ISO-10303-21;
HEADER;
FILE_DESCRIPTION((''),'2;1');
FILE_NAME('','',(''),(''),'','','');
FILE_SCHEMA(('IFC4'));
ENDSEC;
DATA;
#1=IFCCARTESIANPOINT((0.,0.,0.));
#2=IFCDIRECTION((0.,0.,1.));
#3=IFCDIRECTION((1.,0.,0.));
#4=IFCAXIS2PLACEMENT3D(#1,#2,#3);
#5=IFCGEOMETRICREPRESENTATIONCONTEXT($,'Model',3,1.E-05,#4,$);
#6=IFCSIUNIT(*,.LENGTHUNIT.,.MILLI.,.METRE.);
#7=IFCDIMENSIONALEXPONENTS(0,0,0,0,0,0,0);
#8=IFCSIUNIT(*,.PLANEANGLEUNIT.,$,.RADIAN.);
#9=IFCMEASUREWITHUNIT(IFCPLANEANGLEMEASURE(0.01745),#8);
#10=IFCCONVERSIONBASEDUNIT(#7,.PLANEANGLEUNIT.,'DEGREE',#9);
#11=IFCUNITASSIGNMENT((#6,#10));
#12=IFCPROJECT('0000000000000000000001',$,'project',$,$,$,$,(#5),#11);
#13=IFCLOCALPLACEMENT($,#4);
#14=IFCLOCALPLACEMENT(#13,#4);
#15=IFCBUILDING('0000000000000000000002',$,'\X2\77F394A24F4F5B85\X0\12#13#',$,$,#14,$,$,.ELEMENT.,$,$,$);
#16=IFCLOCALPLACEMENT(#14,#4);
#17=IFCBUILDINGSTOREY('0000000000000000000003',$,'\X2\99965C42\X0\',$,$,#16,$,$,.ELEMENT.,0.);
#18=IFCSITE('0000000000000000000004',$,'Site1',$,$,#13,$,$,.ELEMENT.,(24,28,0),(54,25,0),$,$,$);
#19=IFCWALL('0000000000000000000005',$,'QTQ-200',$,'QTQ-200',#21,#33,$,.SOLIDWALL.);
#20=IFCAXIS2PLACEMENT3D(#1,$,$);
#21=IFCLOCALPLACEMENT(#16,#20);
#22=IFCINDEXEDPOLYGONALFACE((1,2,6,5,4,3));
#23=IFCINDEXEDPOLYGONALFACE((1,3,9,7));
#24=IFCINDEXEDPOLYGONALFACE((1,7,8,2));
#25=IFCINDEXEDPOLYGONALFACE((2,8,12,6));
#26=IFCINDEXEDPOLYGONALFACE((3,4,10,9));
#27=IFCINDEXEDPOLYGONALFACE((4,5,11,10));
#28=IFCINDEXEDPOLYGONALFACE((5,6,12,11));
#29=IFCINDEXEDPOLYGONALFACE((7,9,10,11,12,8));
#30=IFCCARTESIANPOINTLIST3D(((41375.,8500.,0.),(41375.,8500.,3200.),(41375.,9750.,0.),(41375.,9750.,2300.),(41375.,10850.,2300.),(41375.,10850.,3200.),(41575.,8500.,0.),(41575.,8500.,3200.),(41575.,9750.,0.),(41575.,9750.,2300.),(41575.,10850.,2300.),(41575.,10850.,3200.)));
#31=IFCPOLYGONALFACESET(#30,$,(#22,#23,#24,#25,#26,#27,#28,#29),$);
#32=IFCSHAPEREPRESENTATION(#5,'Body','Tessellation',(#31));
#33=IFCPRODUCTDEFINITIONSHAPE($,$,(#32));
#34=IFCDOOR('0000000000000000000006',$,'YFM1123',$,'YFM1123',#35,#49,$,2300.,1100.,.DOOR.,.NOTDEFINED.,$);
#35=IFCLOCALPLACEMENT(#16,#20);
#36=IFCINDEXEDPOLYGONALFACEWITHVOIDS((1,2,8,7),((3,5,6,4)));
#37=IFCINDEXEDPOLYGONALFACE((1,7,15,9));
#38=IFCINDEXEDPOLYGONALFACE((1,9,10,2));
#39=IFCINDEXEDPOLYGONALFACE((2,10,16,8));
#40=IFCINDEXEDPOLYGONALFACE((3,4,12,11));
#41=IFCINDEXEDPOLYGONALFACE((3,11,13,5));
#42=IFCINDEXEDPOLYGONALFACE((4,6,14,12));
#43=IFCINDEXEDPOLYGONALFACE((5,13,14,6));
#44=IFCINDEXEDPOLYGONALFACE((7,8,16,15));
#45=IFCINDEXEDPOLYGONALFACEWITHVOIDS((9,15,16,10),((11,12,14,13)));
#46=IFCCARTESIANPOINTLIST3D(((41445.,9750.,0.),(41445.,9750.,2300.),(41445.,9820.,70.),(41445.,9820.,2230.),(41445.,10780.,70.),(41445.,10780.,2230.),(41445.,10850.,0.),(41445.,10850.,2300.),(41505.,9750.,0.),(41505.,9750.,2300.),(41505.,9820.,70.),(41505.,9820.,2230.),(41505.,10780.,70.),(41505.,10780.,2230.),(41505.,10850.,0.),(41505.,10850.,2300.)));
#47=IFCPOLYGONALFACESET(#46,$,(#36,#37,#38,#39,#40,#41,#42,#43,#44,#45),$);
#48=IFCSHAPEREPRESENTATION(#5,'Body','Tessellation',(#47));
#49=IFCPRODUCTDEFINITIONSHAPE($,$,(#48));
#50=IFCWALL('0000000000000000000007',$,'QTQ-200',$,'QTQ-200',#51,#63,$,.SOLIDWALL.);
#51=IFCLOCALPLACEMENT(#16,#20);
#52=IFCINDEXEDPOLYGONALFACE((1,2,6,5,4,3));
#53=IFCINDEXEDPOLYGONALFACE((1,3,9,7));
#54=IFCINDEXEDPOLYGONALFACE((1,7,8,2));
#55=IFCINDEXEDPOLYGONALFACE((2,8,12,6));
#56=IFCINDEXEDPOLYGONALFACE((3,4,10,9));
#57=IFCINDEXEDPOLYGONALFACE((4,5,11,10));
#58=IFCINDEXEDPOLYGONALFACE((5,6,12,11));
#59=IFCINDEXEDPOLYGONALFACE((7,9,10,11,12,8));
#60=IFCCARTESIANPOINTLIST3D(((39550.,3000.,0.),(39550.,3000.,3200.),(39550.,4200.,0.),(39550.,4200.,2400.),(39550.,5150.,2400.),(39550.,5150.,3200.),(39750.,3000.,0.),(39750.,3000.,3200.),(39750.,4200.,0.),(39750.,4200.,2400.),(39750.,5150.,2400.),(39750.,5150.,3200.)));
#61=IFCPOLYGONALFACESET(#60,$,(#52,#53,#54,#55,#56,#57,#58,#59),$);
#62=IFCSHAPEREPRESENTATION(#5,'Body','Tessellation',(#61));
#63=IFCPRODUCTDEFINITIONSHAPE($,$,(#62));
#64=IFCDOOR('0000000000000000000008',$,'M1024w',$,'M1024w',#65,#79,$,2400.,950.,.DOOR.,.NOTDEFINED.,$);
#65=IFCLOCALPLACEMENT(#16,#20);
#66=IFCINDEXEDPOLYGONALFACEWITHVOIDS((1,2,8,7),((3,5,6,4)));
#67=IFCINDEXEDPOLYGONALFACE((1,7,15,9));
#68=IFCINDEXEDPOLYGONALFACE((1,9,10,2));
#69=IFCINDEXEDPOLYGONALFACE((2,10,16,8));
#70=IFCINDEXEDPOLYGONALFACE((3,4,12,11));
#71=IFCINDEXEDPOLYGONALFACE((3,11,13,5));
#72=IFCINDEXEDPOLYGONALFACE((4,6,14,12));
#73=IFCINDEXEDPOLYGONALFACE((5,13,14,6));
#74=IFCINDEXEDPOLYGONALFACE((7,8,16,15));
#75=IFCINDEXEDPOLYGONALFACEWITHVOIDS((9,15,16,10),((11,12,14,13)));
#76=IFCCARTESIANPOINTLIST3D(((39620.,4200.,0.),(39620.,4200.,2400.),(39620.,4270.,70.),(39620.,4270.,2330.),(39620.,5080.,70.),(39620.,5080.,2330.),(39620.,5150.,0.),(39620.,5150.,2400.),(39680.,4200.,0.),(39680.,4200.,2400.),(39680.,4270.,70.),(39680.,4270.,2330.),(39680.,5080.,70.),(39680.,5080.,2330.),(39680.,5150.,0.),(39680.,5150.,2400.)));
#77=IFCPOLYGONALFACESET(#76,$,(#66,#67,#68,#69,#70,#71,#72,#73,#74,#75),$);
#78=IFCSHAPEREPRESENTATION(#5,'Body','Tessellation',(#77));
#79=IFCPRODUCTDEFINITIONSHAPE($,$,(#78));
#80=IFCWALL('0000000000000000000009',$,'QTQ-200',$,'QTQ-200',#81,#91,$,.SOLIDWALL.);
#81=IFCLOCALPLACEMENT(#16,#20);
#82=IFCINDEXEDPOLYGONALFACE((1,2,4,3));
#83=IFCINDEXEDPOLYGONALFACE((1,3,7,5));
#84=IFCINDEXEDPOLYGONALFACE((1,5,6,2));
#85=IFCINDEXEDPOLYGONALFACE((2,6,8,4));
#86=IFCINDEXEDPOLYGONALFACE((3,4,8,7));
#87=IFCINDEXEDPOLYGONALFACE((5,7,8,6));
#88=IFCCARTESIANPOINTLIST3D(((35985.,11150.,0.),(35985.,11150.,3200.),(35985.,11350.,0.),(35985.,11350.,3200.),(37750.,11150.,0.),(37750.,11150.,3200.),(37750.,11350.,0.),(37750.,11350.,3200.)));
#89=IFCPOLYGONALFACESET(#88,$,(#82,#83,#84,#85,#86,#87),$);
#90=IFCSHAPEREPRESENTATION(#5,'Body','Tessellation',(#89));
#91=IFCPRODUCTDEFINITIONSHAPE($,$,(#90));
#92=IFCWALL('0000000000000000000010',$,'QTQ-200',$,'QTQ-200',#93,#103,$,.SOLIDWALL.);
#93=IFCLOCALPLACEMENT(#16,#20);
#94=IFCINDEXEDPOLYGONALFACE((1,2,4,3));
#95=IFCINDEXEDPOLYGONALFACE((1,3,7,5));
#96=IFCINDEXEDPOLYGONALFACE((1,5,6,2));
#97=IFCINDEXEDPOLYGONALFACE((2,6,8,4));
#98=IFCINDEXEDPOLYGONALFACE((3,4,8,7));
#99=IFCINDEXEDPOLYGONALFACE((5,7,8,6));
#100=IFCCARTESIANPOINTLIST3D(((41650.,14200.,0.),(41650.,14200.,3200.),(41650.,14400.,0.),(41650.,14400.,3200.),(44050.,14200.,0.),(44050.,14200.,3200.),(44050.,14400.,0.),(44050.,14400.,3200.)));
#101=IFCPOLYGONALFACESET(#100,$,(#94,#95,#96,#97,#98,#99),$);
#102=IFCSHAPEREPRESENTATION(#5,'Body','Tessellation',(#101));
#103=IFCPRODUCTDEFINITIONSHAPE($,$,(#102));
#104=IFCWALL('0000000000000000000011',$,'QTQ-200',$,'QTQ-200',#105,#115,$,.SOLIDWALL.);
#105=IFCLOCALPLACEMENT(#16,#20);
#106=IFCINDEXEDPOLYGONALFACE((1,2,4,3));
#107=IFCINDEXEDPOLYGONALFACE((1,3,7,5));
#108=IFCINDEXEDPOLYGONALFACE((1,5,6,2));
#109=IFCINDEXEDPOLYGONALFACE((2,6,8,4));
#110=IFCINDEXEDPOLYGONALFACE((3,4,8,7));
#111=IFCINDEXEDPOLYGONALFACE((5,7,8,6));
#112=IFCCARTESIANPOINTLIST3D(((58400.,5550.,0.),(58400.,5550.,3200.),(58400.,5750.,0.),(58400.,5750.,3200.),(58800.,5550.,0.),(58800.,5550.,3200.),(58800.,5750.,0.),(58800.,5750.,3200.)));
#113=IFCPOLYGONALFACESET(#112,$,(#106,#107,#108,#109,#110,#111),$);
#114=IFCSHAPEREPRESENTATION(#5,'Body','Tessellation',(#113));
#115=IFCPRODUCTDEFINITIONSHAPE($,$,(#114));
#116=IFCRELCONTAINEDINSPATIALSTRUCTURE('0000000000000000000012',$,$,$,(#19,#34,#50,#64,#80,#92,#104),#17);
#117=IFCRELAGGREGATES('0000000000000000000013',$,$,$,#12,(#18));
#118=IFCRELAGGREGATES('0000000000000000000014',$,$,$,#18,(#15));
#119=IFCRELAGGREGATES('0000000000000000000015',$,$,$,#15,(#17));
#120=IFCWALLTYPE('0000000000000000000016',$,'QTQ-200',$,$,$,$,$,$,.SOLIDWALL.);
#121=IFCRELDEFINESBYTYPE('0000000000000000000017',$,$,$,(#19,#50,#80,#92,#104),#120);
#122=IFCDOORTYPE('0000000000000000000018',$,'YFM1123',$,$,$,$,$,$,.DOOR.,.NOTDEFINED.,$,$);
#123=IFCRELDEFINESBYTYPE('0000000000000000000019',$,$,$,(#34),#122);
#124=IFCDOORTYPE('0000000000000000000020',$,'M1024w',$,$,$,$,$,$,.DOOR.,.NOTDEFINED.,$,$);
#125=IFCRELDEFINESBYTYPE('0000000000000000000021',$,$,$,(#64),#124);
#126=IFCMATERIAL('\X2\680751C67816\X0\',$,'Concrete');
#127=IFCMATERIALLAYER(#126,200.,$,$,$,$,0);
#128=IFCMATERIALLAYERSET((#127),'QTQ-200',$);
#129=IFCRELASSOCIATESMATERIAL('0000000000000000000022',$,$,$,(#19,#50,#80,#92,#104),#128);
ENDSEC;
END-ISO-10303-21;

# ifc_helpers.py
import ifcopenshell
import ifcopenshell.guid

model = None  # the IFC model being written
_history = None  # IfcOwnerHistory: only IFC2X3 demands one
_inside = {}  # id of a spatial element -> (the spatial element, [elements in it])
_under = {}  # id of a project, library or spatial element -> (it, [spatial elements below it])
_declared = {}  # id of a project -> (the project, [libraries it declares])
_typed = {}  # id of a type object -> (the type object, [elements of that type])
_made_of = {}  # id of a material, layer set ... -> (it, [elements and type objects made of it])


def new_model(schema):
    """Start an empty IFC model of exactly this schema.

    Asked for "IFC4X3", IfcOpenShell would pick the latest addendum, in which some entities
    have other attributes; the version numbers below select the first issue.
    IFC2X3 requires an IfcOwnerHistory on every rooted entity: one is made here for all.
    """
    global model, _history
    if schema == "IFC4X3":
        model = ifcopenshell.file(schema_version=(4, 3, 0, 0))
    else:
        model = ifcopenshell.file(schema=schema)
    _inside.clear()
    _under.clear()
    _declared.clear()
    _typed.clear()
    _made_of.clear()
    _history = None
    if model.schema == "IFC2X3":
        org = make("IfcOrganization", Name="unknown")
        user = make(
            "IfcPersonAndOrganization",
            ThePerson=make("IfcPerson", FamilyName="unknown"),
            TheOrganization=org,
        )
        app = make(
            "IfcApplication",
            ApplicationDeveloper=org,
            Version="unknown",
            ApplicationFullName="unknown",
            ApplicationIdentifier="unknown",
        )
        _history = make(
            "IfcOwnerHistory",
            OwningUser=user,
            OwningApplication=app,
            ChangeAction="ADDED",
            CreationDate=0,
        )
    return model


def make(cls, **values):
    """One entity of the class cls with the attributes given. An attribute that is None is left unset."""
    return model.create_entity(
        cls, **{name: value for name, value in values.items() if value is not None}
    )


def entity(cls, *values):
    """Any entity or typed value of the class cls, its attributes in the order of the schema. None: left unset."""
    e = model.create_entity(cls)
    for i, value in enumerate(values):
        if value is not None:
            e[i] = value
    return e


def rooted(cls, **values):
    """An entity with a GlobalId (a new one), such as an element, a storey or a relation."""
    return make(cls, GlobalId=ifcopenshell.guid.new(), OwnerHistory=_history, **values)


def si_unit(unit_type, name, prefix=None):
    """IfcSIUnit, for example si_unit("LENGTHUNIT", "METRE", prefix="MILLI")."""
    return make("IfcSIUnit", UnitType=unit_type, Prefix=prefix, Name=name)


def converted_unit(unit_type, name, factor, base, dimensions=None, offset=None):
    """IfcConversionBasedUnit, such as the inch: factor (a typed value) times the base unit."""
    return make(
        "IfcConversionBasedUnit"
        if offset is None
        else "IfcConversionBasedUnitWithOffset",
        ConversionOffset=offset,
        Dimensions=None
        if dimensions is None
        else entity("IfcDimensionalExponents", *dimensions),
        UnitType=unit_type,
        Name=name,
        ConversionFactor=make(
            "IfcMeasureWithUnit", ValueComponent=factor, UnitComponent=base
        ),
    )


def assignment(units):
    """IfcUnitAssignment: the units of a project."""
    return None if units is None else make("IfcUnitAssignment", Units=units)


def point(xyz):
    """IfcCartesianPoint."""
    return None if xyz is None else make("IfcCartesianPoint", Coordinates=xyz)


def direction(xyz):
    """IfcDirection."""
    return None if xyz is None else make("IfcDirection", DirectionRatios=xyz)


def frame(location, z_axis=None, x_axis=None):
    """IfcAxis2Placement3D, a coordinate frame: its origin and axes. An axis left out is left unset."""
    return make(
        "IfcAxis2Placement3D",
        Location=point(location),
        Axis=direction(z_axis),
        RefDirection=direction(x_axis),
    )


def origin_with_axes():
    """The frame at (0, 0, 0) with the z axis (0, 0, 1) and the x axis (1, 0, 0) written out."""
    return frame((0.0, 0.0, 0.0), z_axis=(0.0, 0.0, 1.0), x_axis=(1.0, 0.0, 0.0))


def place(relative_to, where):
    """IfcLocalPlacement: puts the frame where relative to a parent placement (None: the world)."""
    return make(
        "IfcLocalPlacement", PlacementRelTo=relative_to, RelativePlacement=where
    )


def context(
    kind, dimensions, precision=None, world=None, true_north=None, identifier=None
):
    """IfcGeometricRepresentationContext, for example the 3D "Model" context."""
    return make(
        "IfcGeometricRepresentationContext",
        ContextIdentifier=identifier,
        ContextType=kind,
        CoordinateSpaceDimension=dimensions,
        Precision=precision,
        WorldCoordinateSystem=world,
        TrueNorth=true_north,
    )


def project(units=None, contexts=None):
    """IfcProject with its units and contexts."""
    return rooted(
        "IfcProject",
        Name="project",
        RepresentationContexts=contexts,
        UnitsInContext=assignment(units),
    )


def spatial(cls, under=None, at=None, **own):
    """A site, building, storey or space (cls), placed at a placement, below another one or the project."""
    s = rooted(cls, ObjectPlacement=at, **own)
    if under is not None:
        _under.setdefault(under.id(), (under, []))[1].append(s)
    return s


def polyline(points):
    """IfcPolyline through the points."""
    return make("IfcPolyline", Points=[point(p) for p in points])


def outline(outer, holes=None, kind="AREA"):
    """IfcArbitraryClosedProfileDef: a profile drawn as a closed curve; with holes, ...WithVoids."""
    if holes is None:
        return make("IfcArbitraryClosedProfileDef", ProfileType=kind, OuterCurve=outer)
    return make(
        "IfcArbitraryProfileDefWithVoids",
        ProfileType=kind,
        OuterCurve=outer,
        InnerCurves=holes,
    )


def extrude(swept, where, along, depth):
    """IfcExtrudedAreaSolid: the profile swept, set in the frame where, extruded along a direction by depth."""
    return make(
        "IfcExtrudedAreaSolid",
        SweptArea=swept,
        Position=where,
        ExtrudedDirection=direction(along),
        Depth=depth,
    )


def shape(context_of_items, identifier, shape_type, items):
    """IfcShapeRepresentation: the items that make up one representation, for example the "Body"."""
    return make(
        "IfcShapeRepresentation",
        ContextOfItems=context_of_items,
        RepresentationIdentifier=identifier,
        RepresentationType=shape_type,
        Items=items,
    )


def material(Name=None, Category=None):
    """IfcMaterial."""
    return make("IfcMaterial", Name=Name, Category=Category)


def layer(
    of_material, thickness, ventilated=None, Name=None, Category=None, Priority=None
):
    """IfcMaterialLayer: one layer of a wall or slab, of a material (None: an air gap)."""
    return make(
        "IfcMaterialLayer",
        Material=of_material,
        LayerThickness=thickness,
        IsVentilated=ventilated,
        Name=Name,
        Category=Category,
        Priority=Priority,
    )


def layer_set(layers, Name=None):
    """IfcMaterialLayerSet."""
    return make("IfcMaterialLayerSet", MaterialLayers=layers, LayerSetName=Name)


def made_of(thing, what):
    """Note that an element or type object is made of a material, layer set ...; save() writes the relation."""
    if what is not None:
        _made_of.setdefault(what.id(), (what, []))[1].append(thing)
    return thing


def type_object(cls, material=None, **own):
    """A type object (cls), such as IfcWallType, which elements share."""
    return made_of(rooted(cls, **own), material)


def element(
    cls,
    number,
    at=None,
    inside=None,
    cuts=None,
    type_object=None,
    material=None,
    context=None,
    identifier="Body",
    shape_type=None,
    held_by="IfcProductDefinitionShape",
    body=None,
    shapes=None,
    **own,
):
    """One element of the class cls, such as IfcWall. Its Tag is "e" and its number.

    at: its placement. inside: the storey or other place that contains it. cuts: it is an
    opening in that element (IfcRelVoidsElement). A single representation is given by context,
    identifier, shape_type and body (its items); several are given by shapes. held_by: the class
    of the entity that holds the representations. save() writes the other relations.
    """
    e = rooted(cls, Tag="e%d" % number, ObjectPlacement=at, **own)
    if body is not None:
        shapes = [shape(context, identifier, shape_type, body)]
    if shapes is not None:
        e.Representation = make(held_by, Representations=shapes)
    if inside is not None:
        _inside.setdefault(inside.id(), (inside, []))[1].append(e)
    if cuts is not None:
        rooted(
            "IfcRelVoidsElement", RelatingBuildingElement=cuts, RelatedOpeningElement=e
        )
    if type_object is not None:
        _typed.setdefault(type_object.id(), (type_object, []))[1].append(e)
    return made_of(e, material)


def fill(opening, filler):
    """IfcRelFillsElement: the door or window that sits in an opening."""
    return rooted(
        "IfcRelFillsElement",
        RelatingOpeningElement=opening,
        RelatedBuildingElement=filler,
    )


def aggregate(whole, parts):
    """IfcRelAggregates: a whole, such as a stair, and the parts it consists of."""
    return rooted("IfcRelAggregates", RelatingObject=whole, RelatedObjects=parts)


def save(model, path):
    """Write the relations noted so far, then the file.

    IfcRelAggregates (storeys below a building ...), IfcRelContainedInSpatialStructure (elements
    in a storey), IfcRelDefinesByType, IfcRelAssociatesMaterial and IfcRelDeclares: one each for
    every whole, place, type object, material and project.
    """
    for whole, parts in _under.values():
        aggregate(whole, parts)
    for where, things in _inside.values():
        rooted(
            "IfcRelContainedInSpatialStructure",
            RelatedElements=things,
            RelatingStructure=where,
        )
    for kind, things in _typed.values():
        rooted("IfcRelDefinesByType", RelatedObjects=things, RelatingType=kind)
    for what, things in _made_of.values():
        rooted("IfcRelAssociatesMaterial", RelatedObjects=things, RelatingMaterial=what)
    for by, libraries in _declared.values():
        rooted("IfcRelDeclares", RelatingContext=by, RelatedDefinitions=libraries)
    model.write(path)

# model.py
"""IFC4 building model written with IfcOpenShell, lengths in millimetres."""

from ifc_helpers import new_model, entity, si_unit, converted_unit, frame, origin_with_axes, place, context, project, spatial, polyline, outline, extrude, material, layer, layer_set, type_object, element, fill, save


model = new_model("IFC4")

# Units and contexts
model_context = context("Model", 3, precision=1e-05, world=origin_with_axes())
ifc_project = project(units=[si_unit("LENGTHUNIT", "METRE", prefix="MILLI"), converted_unit("PLANEANGLEUNIT", "DEGREE", entity("IfcPlaneAngleMeasure", 0.01745), si_unit("PLANEANGLEUNIT", "RADIAN"), dimensions=[0, 0, 0, 0, 0, 0, 0])], contexts=[model_context])

# Site, building, storey
site_placement = place(None, origin_with_axes())
site = spatial("IfcSite", under=ifc_project, at=site_placement, Name="Site1", CompositionType="ELEMENT", RefLatitude=(24, 28, 0), RefLongitude=(54, 25, 0))
building_placement = place(site_placement, origin_with_axes())
building = spatial("IfcBuilding", under=site, at=building_placement, Name="石钢住宅12#13#", CompositionType="ELEMENT")
storey_placement = place(building_placement, origin_with_axes())
storey = spatial("IfcBuildingStorey", under=building, at=storey_placement, Name="首层", CompositionType="ELEMENT", Elevation=0.0)

# Shared definitions
ifc_material_1 = material(Name="标准砖", Category="Concrete")
ifc_layer_1 = layer(ifc_material_1, 200.0, Priority=0)
ifc_layer_set_1 = layer_set([ifc_layer_1], Name="QTQ-200")
wall_type_1 = type_object("IfcWallType", Name="QTQ-200", PredefinedType="SOLIDWALL")

# Walls, openings, doors
wall_1_placement = place(storey_placement, origin_with_axes())
wall_1 = element("IfcWall", 1, at=wall_1_placement, inside=storey, type_object=wall_type_1, material=ifc_layer_set_1, Name="QTQ-200", ObjectType="QTQ-200", PredefinedType="SOLIDWALL", context=model_context, shape_type="SweptSolid", body=[
    extrude(outline(polyline([(0.0, 0.0), (3200.0, 0.0), (3200.0, 2350.0), (0.0, 2350.0), (0.0, 0.0)])), frame((41375.0, 8500.0, 3200.0), z_axis=(1.0, 0.0, 0.0), x_axis=(0.0, 0.0, -1.0)), (0.0, 0.0, 1.0), 200.0),
])
opening_1_placement = place(storey_placement, origin_with_axes())
opening_1 = element("IfcOpeningElement", 2, at=opening_1_placement, cuts=wall_1, PredefinedType="OPENING", context=model_context, shape_type="SweptSolid", body=[
    extrude(outline(polyline([(0.0, 0.0), (2300.0, 0.0), (2300.0, 1100.0), (0.0, 1100.0), (0.0, 0.0)])), frame((40375.0, 10850.0, 0.0), z_axis=(1.0, 0.0, 0.0), x_axis=(0.0, 0.0, 1.0)), (0.0, 0.0, 1.0), 2200.0),
])
door_type_1 = type_object("IfcDoorType", Name="YFM1123", OperationType="NOTDEFINED", PredefinedType="DOOR")
door_1_placement = place(storey_placement, origin_with_axes())
door_1 = element("IfcDoor", 3, at=door_1_placement, inside=storey, type_object=door_type_1, Name="YFM1123", ObjectType="YFM1123", OperationType="NOTDEFINED", OverallHeight=2300.0, OverallWidth=1100.0, PredefinedType="DOOR", context=model_context, shape_type="SweptSolid", body=[
    extrude(outline(polyline([(550.0, -1150.0), (550.0, 1150.0), (-550.0, 1150.0), (-550.0, -1150.0), (550.0, -1150.0)]), holes=[polyline([(480.0, -1080.0), (-480.0, -1080.0), (-480.0, 1080.0), (480.0, 1080.0), (480.0, -1080.0)])]), frame((41445.0, 10300.0, 1150.0), z_axis=(1.0, 0.0, 0.0), x_axis=(0.0, 1.0, 0.0)), (0.0, 0.0, 1.0), 60.0),
])
fill(opening_1, door_1)
wall_2_placement = place(storey_placement, origin_with_axes())
wall_2 = element("IfcWall", 4, at=wall_2_placement, inside=storey, type_object=wall_type_1, material=ifc_layer_set_1, Name="QTQ-200", ObjectType="QTQ-200", PredefinedType="SOLIDWALL", context=model_context, shape_type="SweptSolid", body=[
    extrude(outline(polyline([(0.0, 0.0), (3200.0, 0.0), (3200.0, 2150.0), (0.0, 2150.0), (0.0, 0.0)])), frame((39550.0, 3000.0, 3200.0), z_axis=(1.0, 0.0, 0.0), x_axis=(0.0, 0.0, -1.0)), (0.0, 0.0, 1.0), 200.0),
])
opening_2_placement = place(storey_placement, origin_with_axes())
opening_2 = element("IfcOpeningElement", 5, at=opening_2_placement, cuts=wall_2, PredefinedType="OPENING", context=model_context, shape_type="SweptSolid", body=[
    extrude(outline(polyline([(0.0, 0.0), (950.0, 0.0), (950.0, 2400.0), (0.0, 2400.0), (0.0, 0.0)])), frame((38550.0, 4200.0, 0.0), z_axis=(1.0, 0.0, 0.0), x_axis=(0.0, 1.0, 0.0)), (0.0, 0.0, 1.0), 2200.0),
])
door_type_2 = type_object("IfcDoorType", Name="M1024w", OperationType="NOTDEFINED", PredefinedType="DOOR")
door_2_placement = place(storey_placement, origin_with_axes())
door_2 = element("IfcDoor", 6, at=door_2_placement, inside=storey, type_object=door_type_2, Name="M1024w", ObjectType="M1024w", OperationType="NOTDEFINED", OverallHeight=2400.0, OverallWidth=950.0, PredefinedType="DOOR", context=model_context, shape_type="SweptSolid", body=[
    extrude(outline(polyline([(-475.0, -1200.0), (475.0, -1200.0), (475.0, 1200.0), (-475.0, 1200.0), (-475.0, -1200.0)]), holes=[polyline([(-405.0, -1130.0), (-405.0, 1130.0), (405.0, 1130.0), (405.0, -1130.0), (-405.0, -1130.0)])]), frame((39620.0, 4675.0, 1200.0), z_axis=(1.0, 0.0, 0.0), x_axis=(0.0, 1.0, 0.0)), (0.0, 0.0, 1.0), 60.0),
])
fill(opening_2, door_2)

# Walls
wall_3_placement = place(storey_placement, origin_with_axes())
element("IfcWall", 7, at=wall_3_placement, inside=storey, type_object=wall_type_1, material=ifc_layer_set_1, Name="QTQ-200", ObjectType="QTQ-200", PredefinedType="SOLIDWALL", context=model_context, shape_type="SweptSolid", body=[
    extrude(outline(polyline([(0.0, 0.0), (3200.0, 0.0), (3200.0, 1765.0), (0.0, 1765.0), (0.0, 0.0)])), frame((37750.0, 11150.0, 3200.0), z_axis=(0.0, 1.0, 0.0), x_axis=(0.0, 0.0, -1.0)), (0.0, 0.0, 1.0), 200.0),
])
wall_4_placement = place(storey_placement, origin_with_axes())
element("IfcWall", 8, at=wall_4_placement, inside=storey, type_object=wall_type_1, material=ifc_layer_set_1, Name="QTQ-200", ObjectType="QTQ-200", PredefinedType="SOLIDWALL", context=model_context, shape_type="SweptSolid", body=[
    extrude(outline(polyline([(0.0, 0.0), (3200.0, 0.0), (3200.0, 2400.0), (0.0, 2400.0), (0.0, 0.0)])), frame((44050.0, 14200.0, 3200.0), z_axis=(0.0, 1.0, 0.0), x_axis=(0.0, 0.0, -1.0)), (0.0, 0.0, 1.0), 200.0),
])
wall_5_placement = place(storey_placement, origin_with_axes())
element("IfcWall", 9, at=wall_5_placement, inside=storey, type_object=wall_type_1, material=ifc_layer_set_1, Name="QTQ-200", ObjectType="QTQ-200", PredefinedType="SOLIDWALL", context=model_context, shape_type="SweptSolid", body=[
    extrude(outline(polyline([(0.0, 0.0), (3200.0, 0.0), (3200.0, 400.0), (0.0, 400.0), (0.0, 0.0)])), frame((58800.0, 5550.0, 3200.0), z_axis=(0.0, 1.0, 0.0), x_axis=(0.0, 0.0, -1.0)), (0.0, 0.0, 1.0), 200.0),
])

save(model, "model.ifc")
